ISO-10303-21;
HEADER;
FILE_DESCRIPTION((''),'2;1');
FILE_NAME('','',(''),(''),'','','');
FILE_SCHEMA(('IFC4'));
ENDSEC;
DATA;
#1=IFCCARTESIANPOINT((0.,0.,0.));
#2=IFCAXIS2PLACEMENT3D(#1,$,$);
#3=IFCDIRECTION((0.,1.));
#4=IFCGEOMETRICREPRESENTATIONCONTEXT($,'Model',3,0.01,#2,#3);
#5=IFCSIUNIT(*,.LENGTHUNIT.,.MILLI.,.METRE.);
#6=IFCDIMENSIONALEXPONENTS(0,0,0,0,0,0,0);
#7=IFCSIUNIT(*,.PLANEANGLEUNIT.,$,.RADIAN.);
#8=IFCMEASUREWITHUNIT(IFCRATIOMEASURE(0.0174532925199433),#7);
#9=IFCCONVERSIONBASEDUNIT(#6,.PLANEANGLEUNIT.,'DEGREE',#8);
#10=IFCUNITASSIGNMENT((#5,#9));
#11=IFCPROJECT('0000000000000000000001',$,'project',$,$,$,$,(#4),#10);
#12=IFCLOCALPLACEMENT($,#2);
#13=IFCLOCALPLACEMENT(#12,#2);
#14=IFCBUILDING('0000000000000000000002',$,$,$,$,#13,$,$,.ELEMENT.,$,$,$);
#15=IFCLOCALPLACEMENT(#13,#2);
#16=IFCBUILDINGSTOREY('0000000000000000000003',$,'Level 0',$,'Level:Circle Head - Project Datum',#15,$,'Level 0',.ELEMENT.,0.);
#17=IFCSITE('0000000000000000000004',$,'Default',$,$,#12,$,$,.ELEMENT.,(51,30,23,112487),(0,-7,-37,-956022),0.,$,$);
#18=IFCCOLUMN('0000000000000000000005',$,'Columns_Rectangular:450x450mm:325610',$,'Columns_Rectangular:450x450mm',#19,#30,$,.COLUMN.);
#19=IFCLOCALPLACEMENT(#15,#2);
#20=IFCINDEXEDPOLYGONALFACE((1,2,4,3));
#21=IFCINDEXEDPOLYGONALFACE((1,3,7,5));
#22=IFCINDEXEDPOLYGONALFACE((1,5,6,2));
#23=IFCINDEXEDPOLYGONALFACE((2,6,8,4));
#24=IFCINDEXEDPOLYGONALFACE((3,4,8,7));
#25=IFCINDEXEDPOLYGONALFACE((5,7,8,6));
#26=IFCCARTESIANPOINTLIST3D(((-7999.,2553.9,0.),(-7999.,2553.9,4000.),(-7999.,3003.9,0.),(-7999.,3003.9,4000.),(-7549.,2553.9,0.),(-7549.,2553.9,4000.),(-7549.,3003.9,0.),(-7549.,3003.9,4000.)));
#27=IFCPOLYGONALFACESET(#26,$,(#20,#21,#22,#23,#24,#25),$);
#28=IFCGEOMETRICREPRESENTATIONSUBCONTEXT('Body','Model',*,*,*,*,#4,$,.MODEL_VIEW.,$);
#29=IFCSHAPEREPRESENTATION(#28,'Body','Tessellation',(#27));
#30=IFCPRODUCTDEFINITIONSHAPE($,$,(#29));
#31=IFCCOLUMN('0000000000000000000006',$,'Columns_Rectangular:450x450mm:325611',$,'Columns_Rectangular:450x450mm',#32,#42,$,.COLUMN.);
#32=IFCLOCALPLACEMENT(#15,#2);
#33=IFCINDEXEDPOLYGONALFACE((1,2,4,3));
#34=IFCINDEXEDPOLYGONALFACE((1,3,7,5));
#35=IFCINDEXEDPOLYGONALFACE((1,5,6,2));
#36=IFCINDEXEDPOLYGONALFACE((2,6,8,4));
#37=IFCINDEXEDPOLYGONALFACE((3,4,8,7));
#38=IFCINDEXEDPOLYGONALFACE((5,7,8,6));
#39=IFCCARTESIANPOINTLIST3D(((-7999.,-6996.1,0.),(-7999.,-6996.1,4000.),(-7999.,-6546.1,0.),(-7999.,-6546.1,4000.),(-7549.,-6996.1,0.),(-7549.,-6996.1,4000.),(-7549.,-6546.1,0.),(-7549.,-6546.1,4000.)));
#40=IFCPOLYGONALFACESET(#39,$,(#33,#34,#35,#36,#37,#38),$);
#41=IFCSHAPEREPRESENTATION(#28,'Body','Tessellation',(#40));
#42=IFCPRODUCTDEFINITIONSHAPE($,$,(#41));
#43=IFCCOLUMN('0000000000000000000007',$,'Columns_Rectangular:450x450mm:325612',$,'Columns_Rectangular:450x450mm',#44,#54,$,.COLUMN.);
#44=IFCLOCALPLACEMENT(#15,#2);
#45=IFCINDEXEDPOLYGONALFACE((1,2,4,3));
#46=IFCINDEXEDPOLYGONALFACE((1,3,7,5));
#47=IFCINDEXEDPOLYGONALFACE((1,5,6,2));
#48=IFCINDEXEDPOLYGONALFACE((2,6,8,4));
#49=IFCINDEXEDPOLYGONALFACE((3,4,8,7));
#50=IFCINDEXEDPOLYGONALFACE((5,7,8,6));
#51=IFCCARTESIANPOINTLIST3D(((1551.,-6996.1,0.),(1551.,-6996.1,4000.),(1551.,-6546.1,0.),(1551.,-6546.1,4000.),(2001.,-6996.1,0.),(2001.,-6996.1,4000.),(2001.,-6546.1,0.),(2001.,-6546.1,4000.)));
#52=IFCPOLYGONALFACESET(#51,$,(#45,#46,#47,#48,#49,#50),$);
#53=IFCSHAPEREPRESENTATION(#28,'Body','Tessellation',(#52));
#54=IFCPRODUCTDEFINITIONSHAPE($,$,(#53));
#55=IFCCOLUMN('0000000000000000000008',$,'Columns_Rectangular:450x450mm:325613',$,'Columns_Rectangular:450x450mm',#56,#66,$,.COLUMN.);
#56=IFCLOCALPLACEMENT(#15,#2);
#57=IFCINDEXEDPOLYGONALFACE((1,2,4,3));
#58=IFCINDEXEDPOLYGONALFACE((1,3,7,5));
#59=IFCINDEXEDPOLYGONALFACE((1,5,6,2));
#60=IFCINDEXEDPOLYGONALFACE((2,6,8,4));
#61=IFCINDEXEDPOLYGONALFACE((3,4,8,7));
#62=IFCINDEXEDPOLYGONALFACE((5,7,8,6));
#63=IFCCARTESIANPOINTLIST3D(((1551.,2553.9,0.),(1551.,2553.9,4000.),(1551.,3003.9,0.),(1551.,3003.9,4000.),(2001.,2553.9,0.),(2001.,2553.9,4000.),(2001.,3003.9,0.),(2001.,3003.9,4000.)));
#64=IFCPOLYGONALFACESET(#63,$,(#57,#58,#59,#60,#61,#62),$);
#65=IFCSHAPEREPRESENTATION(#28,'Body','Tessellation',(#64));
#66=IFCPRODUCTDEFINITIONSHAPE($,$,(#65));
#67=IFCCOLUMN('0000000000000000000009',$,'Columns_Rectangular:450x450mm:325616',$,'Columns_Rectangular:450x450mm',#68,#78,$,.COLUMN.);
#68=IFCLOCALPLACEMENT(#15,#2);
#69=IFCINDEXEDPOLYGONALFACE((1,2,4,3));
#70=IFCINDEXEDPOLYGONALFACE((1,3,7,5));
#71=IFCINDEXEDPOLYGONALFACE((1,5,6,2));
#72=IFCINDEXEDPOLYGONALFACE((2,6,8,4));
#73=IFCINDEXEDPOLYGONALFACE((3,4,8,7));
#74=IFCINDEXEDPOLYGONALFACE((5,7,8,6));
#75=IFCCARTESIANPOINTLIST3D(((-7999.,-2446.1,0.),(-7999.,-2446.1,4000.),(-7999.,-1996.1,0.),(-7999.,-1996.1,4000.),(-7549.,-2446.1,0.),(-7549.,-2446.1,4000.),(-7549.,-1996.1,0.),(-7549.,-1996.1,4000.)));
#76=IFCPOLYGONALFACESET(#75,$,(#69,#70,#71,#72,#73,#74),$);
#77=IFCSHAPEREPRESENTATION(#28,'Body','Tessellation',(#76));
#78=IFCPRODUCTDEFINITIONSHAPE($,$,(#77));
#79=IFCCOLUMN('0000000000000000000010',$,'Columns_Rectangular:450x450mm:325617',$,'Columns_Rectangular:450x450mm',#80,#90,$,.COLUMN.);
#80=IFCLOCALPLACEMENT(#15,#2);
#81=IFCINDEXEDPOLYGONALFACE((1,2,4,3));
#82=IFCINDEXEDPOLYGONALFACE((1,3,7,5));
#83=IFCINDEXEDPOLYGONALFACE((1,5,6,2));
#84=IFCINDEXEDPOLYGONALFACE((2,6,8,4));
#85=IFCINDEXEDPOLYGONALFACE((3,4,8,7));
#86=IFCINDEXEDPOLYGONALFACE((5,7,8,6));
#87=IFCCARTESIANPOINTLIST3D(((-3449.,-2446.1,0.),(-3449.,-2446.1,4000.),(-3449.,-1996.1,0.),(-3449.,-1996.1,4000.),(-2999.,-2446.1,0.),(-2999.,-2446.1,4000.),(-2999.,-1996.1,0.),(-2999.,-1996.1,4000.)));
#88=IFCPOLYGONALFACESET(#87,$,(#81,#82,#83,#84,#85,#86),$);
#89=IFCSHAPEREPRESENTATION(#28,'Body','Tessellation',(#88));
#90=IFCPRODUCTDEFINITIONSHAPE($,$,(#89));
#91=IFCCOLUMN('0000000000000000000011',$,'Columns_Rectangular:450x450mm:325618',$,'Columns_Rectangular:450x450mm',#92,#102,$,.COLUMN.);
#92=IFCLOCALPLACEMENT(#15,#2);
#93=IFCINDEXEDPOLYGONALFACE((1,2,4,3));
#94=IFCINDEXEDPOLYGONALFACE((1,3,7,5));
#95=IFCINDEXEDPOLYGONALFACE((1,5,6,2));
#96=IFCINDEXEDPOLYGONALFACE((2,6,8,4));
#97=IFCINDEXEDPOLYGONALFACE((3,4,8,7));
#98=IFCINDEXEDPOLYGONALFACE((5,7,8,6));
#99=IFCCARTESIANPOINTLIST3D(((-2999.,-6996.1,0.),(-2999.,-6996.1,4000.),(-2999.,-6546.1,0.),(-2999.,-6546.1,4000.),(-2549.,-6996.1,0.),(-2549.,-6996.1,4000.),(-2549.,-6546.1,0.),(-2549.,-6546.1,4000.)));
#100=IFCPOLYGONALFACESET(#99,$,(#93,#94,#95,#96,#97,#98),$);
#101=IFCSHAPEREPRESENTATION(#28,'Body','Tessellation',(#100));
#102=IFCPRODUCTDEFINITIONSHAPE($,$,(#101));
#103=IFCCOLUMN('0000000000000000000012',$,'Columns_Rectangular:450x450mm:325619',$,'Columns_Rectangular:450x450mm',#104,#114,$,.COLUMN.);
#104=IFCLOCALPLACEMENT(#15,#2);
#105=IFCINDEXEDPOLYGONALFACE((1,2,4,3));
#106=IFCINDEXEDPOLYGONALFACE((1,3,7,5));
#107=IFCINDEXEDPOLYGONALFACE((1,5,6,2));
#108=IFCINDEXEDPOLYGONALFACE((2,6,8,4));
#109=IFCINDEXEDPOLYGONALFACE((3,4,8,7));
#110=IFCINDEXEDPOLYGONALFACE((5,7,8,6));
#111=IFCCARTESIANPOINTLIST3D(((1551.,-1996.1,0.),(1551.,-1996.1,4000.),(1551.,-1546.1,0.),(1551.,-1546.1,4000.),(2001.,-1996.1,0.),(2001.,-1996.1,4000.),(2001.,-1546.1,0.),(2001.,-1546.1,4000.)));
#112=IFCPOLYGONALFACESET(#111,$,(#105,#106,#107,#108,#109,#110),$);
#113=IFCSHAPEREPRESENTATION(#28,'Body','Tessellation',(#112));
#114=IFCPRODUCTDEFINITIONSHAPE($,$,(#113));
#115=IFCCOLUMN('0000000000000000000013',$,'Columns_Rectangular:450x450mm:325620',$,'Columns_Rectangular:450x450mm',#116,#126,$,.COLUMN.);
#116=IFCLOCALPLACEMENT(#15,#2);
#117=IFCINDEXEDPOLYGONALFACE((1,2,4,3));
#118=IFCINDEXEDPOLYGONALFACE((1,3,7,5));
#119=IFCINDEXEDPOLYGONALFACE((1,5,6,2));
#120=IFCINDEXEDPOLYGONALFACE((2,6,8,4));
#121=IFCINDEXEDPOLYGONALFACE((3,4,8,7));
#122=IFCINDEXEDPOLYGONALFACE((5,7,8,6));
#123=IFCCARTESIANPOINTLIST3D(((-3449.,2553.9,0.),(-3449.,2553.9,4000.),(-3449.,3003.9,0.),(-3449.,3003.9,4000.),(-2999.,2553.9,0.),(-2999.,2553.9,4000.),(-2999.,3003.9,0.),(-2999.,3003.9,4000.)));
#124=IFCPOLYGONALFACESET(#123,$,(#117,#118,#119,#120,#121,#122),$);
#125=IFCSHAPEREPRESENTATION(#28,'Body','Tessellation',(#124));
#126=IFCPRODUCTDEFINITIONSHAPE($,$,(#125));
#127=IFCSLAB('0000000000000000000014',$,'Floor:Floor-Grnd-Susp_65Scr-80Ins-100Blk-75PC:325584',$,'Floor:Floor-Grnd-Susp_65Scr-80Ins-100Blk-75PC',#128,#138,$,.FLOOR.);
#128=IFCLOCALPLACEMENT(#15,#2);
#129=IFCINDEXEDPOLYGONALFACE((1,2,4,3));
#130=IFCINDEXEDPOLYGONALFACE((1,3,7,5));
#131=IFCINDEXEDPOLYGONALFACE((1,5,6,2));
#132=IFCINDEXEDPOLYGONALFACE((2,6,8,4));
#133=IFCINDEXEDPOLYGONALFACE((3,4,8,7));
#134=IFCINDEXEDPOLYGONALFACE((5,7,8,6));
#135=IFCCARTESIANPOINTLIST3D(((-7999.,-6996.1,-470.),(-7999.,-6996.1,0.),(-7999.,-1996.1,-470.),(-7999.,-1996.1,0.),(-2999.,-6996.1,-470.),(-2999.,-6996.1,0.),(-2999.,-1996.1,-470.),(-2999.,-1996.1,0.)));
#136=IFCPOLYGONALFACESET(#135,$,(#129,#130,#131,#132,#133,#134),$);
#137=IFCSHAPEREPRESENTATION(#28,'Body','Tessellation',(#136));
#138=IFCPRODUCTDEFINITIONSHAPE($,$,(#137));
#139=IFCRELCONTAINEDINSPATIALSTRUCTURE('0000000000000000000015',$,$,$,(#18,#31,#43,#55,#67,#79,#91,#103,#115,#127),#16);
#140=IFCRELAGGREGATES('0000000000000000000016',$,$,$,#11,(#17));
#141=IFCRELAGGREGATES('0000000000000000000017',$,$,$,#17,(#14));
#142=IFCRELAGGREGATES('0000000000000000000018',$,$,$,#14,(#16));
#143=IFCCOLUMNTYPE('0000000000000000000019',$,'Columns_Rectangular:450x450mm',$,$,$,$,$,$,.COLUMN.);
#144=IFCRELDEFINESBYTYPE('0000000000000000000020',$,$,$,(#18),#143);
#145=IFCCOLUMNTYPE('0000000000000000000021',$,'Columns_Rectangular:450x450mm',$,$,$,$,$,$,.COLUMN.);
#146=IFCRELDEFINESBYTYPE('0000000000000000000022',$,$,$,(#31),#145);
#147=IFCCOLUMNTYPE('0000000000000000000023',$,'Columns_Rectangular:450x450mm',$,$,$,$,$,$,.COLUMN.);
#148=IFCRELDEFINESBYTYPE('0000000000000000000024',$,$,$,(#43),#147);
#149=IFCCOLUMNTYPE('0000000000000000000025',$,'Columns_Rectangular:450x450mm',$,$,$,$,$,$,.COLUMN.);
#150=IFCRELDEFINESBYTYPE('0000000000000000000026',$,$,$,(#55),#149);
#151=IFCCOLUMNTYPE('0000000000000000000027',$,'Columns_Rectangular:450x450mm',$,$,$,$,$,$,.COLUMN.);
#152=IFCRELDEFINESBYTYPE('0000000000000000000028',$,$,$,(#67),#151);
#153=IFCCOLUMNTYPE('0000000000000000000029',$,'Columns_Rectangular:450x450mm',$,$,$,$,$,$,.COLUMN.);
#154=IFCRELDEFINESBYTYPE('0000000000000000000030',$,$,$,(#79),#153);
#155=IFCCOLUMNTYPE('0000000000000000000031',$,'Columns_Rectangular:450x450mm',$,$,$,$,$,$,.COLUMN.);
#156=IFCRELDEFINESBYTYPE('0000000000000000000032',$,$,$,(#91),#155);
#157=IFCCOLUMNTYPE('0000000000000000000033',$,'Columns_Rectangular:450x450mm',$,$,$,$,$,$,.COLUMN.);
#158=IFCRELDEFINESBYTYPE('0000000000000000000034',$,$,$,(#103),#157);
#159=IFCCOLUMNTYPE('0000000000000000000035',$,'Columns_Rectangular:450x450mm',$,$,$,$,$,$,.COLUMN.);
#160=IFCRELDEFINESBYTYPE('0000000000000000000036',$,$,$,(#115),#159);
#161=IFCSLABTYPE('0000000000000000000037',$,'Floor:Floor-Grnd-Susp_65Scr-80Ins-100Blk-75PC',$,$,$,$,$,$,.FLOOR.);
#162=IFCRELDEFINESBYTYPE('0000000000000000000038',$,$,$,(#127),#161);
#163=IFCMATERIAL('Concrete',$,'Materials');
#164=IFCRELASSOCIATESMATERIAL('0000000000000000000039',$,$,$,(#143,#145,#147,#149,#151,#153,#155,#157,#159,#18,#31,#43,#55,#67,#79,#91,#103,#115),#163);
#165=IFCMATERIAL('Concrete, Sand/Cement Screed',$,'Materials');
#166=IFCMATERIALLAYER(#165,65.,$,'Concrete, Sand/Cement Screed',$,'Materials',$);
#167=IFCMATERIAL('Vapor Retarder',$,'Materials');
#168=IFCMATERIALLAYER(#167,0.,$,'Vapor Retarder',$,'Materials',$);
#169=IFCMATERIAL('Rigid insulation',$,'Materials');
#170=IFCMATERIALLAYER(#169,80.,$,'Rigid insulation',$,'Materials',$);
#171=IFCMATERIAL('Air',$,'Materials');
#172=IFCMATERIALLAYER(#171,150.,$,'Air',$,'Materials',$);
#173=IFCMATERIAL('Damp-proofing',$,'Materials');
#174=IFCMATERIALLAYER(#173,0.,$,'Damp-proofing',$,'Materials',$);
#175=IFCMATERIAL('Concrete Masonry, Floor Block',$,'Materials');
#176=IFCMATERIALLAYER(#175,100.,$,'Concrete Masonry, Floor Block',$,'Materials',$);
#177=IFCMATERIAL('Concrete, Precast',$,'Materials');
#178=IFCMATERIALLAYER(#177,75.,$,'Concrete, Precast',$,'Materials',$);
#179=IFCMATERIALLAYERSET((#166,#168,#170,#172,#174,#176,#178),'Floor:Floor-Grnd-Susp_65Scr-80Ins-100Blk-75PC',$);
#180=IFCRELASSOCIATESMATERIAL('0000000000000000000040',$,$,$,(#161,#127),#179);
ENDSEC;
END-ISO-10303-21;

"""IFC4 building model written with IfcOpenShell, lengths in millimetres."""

from ifc_helpers import new_model, entity, si_unit, converted_unit, direction, frame, frame_2d, origin, origin_2d_with_axis, place, context, subcontext, project, spatial, polyline, segment, composite_curve, rectangle, outline, extrude, source, transform, mapped, material, layer, layer_set, layer_usage, material_profile, profile_set, profile_usage, type_object, type_shapes, element, save


model = new_model("IFC4")

# Units and contexts
model_context = context("Model", 3, precision=0.01, world=origin(), true_north=direction((0.0, 1.0)))
body_context = subcontext(model_context, "Body", "Model", "MODEL_VIEW")
ifc_project = project(units=[si_unit("LENGTHUNIT", "METRE", prefix="MILLI"), converted_unit("PLANEANGLEUNIT", "DEGREE", entity("IfcRatioMeasure", 0.0174532925199433), si_unit("PLANEANGLEUNIT", "RADIAN"), dimensions=[0, 0, 0, 0, 0, 0, 0])], contexts=[model_context])

# Site, building, storey
site_placement = place(None, origin())
site = spatial("IfcSite", under=ifc_project, at=site_placement, Name="Default", CompositionType="ELEMENT", RefLatitude=(51, 30, 23, 112487), RefLongitude=(0, -7, -37, -956022), RefElevation=0.0)
building_placement = place(site_placement, origin())
building = spatial("IfcBuilding", under=site, at=building_placement, CompositionType="ELEMENT")
storey_placement = place(building_placement, origin())
storey = spatial("IfcBuildingStorey", under=building, at=storey_placement, Name="Level 0", ObjectType="Level:Circle Head - Project Datum", LongName="Level 0", CompositionType="ELEMENT", Elevation=0.0)

# Columns
ifc_material_1 = material(Name="Concrete", Category="Materials")
ifc_material_profile = material_profile(ifc_material_1, outline(composite_curve([segment(polyline([(225.0, 225.0, 0.0), (225.0, -225.0, 0.0)]), True, "CONTINUOUS"), segment(polyline([(225.0, -225.0, 0.0), (-225.0, -225.0, 0.0)]), True, "CONTINUOUS"), segment(polyline([(-225.0, -225.0, 0.0), (-225.0, 225.0, 0.0)]), True, "CONTINUOUS"), segment(polyline([(-225.0, 225.0, 0.0), (225.0, 225.0, 0.0)]), True, "CONTINUOUS")], self_intersect=False), kind="CURVE"), Name="450x450mm")
ifc_profile_set = profile_set([ifc_material_profile], Name="450x450mm")
ifc_profile_usage_1 = profile_usage(ifc_profile_set)
column_type_1 = type_object("IfcColumnType", Name="Columns_Rectangular:450x450mm", PredefinedType="COLUMN", material=ifc_profile_set)
shared_shape_1 = source(origin(), body_context, "Body", "SweptSolid", [
    extrude(rectangle(XDim=450.0, YDim=450.0, at=frame_2d((0.0, 0.0), x_axis=(1.0, 0.0))), frame((-7774.0, 2778.9, 0.0), z_axis=(0.0, 0.0, 1.0), x_axis=(0.0, -1.0, 0.0)), (0.0, 0.0, 1.0), 4000.0),
])
type_shapes(column_type_1, [shared_shape_1])
column_1_placement = place(storey_placement, origin())
element("IfcColumn", 1, at=column_1_placement, inside=storey, type_object=column_type_1, material=ifc_profile_usage_1, Name="Columns_Rectangular:450x450mm:325610", ObjectType="Columns_Rectangular:450x450mm", PredefinedType="COLUMN", context=body_context, shape_type="MappedRepresentation", body=[
    mapped(shared_shape_1, transform((0.0, 0.0, 0.0), scale=1.0)),
])
ifc_profile_usage_2 = profile_usage(ifc_profile_set)
column_type_2 = type_object("IfcColumnType", Name="Columns_Rectangular:450x450mm", PredefinedType="COLUMN", material=ifc_profile_set)
shared_shape_2 = source(origin(), body_context, "Body", "SweptSolid", [
    extrude(rectangle(XDim=450.0, YDim=450.0, at=frame_2d((0.0, 0.0), x_axis=(1.0, 0.0))), frame((-7774.0, -6771.1, 0.0), z_axis=(0.0, 0.0, 1.0), x_axis=(0.0, -1.0, 0.0)), (0.0, 0.0, 1.0), 4000.0),
])
type_shapes(column_type_2, [shared_shape_2])
column_2_placement = place(storey_placement, origin())
element("IfcColumn", 2, at=column_2_placement, inside=storey, type_object=column_type_2, material=ifc_profile_usage_2, Name="Columns_Rectangular:450x450mm:325611", ObjectType="Columns_Rectangular:450x450mm", PredefinedType="COLUMN", context=body_context, shape_type="MappedRepresentation", body=[
    mapped(shared_shape_2, transform((0.0, 0.0, 0.0), scale=1.0)),
])
ifc_profile_usage_3 = profile_usage(ifc_profile_set)
column_type_3 = type_object("IfcColumnType", Name="Columns_Rectangular:450x450mm", PredefinedType="COLUMN", material=ifc_profile_set)
shared_shape_3 = source(origin(), body_context, "Body", "SweptSolid", [
    extrude(rectangle(XDim=450.0, YDim=450.0, at=frame_2d((0.0, 0.0), x_axis=(1.0, 0.0))), frame((1776.0, -6771.1, 0.0), z_axis=(0.0, 0.0, 1.0), x_axis=(0.0, -1.0, 0.0)), (0.0, 0.0, 1.0), 4000.0),
])
type_shapes(column_type_3, [shared_shape_3])
column_3_placement = place(storey_placement, origin())
element("IfcColumn", 3, at=column_3_placement, inside=storey, type_object=column_type_3, material=ifc_profile_usage_3, Name="Columns_Rectangular:450x450mm:325612", ObjectType="Columns_Rectangular:450x450mm", PredefinedType="COLUMN", context=body_context, shape_type="MappedRepresentation", body=[
    mapped(shared_shape_3, transform((0.0, 0.0, 0.0), scale=1.0)),
])
ifc_profile_usage_4 = profile_usage(ifc_profile_set)
column_type_4 = type_object("IfcColumnType", Name="Columns_Rectangular:450x450mm", PredefinedType="COLUMN", material=ifc_profile_set)
shared_shape_4 = source(origin(), body_context, "Body", "SweptSolid", [
    extrude(rectangle(XDim=450.0, YDim=450.0, at=frame_2d((0.0, 0.0), x_axis=(1.0, 0.0))), frame((1776.0, 2778.9, 0.0), z_axis=(0.0, 0.0, 1.0), x_axis=(0.0, -1.0, 0.0)), (0.0, 0.0, 1.0), 4000.0),
])
type_shapes(column_type_4, [shared_shape_4])
column_4_placement = place(storey_placement, origin())
element("IfcColumn", 4, at=column_4_placement, inside=storey, type_object=column_type_4, material=ifc_profile_usage_4, Name="Columns_Rectangular:450x450mm:325613", ObjectType="Columns_Rectangular:450x450mm", PredefinedType="COLUMN", context=body_context, shape_type="MappedRepresentation", body=[
    mapped(shared_shape_4, transform((0.0, 0.0, 0.0), scale=1.0)),
])
ifc_profile_usage_5 = profile_usage(ifc_profile_set)
column_type_5 = type_object("IfcColumnType", Name="Columns_Rectangular:450x450mm", PredefinedType="COLUMN", material=ifc_profile_set)
shared_shape_5 = source(origin(), body_context, "Body", "SweptSolid", [
    extrude(rectangle(XDim=450.0, YDim=450.0, at=frame_2d((0.0, 0.0), x_axis=(1.0, 0.0))), frame((-7774.0, -2221.1, 0.0), z_axis=(0.0, 0.0, 1.0), x_axis=(0.0, -1.0, 0.0)), (0.0, 0.0, 1.0), 4000.0),
])
type_shapes(column_type_5, [shared_shape_5])
column_5_placement = place(storey_placement, origin())
element("IfcColumn", 5, at=column_5_placement, inside=storey, type_object=column_type_5, material=ifc_profile_usage_5, Name="Columns_Rectangular:450x450mm:325616", ObjectType="Columns_Rectangular:450x450mm", PredefinedType="COLUMN", context=body_context, shape_type="MappedRepresentation", body=[
    mapped(shared_shape_5, transform((0.0, 0.0, 0.0), scale=1.0)),
])
ifc_profile_usage_6 = profile_usage(ifc_profile_set)
column_type_6 = type_object("IfcColumnType", Name="Columns_Rectangular:450x450mm", PredefinedType="COLUMN", material=ifc_profile_set)
shared_shape_6 = source(origin(), body_context, "Body", "SweptSolid", [
    extrude(rectangle(XDim=450.0, YDim=450.0, at=origin_2d_with_axis()), frame((0.0, 0.0, 0.0), z_axis=(0.0, 0.0, 1.0), x_axis=(0.0, -1.0, 0.0)), (0.0, 0.0, 1.0), 4000.0),
])
type_shapes(column_type_6, [shared_shape_6])
column_6_placement = place(storey_placement, frame((-3224.0, -2221.1, 0.0)))
element("IfcColumn", 6, at=column_6_placement, inside=storey, type_object=column_type_6, material=ifc_profile_usage_6, Name="Columns_Rectangular:450x450mm:325617", ObjectType="Columns_Rectangular:450x450mm", PredefinedType="COLUMN", context=body_context, shape_type="MappedRepresentation", body=[
    mapped(shared_shape_6, transform((0.0, 0.0, 0.0), scale=1.0)),
])
ifc_profile_usage_7 = profile_usage(ifc_profile_set)
column_type_7 = type_object("IfcColumnType", Name="Columns_Rectangular:450x450mm", PredefinedType="COLUMN", material=ifc_profile_set)
shared_shape_7 = source(origin(), body_context, "Body", "SweptSolid", [
    extrude(rectangle(XDim=450.0, YDim=450.0, at=frame_2d((0.0, 0.0), x_axis=(1.0, 0.0))), frame((-2774.0, -6771.1, 0.0), z_axis=(0.0, 0.0, 1.0), x_axis=(0.0, -1.0, 0.0)), (0.0, 0.0, 1.0), 4000.0),
])
type_shapes(column_type_7, [shared_shape_7])
column_7_placement = place(storey_placement, origin())
element("IfcColumn", 7, at=column_7_placement, inside=storey, type_object=column_type_7, material=ifc_profile_usage_7, Name="Columns_Rectangular:450x450mm:325618", ObjectType="Columns_Rectangular:450x450mm", PredefinedType="COLUMN", context=body_context, shape_type="MappedRepresentation", body=[
    mapped(shared_shape_7, transform((0.0, 0.0, 0.0), scale=1.0)),
])
ifc_profile_usage_8 = profile_usage(ifc_profile_set)
column_type_8 = type_object("IfcColumnType", Name="Columns_Rectangular:450x450mm", PredefinedType="COLUMN", material=ifc_profile_set)
shared_shape_8 = source(origin(), body_context, "Body", "SweptSolid", [
    extrude(rectangle(XDim=450.0, YDim=450.0, at=frame_2d((0.0, 0.0), x_axis=(1.0, 0.0))), frame((1776.0, -1771.1, 0.0), z_axis=(0.0, 0.0, 1.0), x_axis=(0.0, -1.0, 0.0)), (0.0, 0.0, 1.0), 4000.0),
])
type_shapes(column_type_8, [shared_shape_8])
column_8_placement = place(storey_placement, origin())
element("IfcColumn", 8, at=column_8_placement, inside=storey, type_object=column_type_8, material=ifc_profile_usage_8, Name="Columns_Rectangular:450x450mm:325619", ObjectType="Columns_Rectangular:450x450mm", PredefinedType="COLUMN", context=body_context, shape_type="MappedRepresentation", body=[
    mapped(shared_shape_8, transform((0.0, 0.0, 0.0), scale=1.0)),
])
ifc_profile_usage_9 = profile_usage(ifc_profile_set)
column_type_9 = type_object("IfcColumnType", Name="Columns_Rectangular:450x450mm", PredefinedType="COLUMN", material=ifc_profile_set)
shared_shape_9 = source(origin(), body_context, "Body", "SweptSolid", [
    extrude(rectangle(XDim=450.0, YDim=450.0, at=frame_2d((0.0, 0.0), x_axis=(1.0, 0.0))), frame((-3224.0, 2778.9, 0.0), z_axis=(0.0, 0.0, 1.0), x_axis=(0.0, -1.0, 0.0)), (0.0, 0.0, 1.0), 4000.0),
])
type_shapes(column_type_9, [shared_shape_9])
column_9_placement = place(storey_placement, origin())
element("IfcColumn", 9, at=column_9_placement, inside=storey, type_object=column_type_9, material=ifc_profile_usage_9, Name="Columns_Rectangular:450x450mm:325620", ObjectType="Columns_Rectangular:450x450mm", PredefinedType="COLUMN", context=body_context, shape_type="MappedRepresentation", body=[
    mapped(shared_shape_9, transform((0.0, 0.0, 0.0), scale=1.0)),
])

# Slab
ifc_material_2 = material(Name="Concrete, Sand/Cement Screed", Category="Materials")
ifc_layer_1 = layer(ifc_material_2, 65.0, Name="Concrete, Sand/Cement Screed", Category="Materials")
ifc_material_3 = material(Name="Vapor Retarder", Category="Materials")
ifc_layer_2 = layer(ifc_material_3, 0.0, Name="Vapor Retarder", Category="Materials")
ifc_material_4 = material(Name="Rigid insulation", Category="Materials")
ifc_layer_3 = layer(ifc_material_4, 80.0, Name="Rigid insulation", Category="Materials")
ifc_material_5 = material(Name="Air", Category="Materials")
ifc_layer_4 = layer(ifc_material_5, 150.0, Name="Air", Category="Materials")
ifc_material_6 = material(Name="Damp-proofing", Category="Materials")
ifc_layer_5 = layer(ifc_material_6, 0.0, Name="Damp-proofing", Category="Materials")
ifc_material_7 = material(Name="Concrete Masonry, Floor Block", Category="Materials")
ifc_layer_6 = layer(ifc_material_7, 100.0, Name="Concrete Masonry, Floor Block", Category="Materials")
ifc_material_8 = material(Name="Concrete, Precast", Category="Materials")
ifc_layer_7 = layer(ifc_material_8, 75.0, Name="Concrete, Precast", Category="Materials")
ifc_layer_set_1 = layer_set([ifc_layer_1, ifc_layer_2, ifc_layer_3, ifc_layer_4, ifc_layer_5, ifc_layer_6, ifc_layer_7], Name="Floor:Floor-Grnd-Susp_65Scr-80Ins-100Blk-75PC")
ifc_layer_usage_1 = layer_usage(ifc_layer_set_1, "AXIS3", "POSITIVE", 0.0)
slab_type_1 = type_object("IfcSlabType", Name="Floor:Floor-Grnd-Susp_65Scr-80Ins-100Blk-75PC", PredefinedType="FLOOR", material=ifc_layer_set_1)
slab_1_placement = place(storey_placement, origin())
element("IfcSlab", 10, at=slab_1_placement, inside=storey, type_object=slab_type_1, material=ifc_layer_usage_1, Name="Floor:Floor-Grnd-Susp_65Scr-80Ins-100Blk-75PC:325584", ObjectType="Floor:Floor-Grnd-Susp_65Scr-80Ins-100Blk-75PC", PredefinedType="FLOOR", context=body_context, shape_type="SweptSolid", body=[
    extrude(rectangle(XDim=5000.0, YDim=5000.0, at=frame_2d((0.0, 0.0), x_axis=(1.0, 0.0))), frame((-5499.0, -4496.1, 0.0), z_axis=(0.0, 0.0, -1.0), x_axis=(0.0, 1.0, 0.0)), (0.0, 0.0, 1.0), 470.0),
])

save(model, "model.ifc")
